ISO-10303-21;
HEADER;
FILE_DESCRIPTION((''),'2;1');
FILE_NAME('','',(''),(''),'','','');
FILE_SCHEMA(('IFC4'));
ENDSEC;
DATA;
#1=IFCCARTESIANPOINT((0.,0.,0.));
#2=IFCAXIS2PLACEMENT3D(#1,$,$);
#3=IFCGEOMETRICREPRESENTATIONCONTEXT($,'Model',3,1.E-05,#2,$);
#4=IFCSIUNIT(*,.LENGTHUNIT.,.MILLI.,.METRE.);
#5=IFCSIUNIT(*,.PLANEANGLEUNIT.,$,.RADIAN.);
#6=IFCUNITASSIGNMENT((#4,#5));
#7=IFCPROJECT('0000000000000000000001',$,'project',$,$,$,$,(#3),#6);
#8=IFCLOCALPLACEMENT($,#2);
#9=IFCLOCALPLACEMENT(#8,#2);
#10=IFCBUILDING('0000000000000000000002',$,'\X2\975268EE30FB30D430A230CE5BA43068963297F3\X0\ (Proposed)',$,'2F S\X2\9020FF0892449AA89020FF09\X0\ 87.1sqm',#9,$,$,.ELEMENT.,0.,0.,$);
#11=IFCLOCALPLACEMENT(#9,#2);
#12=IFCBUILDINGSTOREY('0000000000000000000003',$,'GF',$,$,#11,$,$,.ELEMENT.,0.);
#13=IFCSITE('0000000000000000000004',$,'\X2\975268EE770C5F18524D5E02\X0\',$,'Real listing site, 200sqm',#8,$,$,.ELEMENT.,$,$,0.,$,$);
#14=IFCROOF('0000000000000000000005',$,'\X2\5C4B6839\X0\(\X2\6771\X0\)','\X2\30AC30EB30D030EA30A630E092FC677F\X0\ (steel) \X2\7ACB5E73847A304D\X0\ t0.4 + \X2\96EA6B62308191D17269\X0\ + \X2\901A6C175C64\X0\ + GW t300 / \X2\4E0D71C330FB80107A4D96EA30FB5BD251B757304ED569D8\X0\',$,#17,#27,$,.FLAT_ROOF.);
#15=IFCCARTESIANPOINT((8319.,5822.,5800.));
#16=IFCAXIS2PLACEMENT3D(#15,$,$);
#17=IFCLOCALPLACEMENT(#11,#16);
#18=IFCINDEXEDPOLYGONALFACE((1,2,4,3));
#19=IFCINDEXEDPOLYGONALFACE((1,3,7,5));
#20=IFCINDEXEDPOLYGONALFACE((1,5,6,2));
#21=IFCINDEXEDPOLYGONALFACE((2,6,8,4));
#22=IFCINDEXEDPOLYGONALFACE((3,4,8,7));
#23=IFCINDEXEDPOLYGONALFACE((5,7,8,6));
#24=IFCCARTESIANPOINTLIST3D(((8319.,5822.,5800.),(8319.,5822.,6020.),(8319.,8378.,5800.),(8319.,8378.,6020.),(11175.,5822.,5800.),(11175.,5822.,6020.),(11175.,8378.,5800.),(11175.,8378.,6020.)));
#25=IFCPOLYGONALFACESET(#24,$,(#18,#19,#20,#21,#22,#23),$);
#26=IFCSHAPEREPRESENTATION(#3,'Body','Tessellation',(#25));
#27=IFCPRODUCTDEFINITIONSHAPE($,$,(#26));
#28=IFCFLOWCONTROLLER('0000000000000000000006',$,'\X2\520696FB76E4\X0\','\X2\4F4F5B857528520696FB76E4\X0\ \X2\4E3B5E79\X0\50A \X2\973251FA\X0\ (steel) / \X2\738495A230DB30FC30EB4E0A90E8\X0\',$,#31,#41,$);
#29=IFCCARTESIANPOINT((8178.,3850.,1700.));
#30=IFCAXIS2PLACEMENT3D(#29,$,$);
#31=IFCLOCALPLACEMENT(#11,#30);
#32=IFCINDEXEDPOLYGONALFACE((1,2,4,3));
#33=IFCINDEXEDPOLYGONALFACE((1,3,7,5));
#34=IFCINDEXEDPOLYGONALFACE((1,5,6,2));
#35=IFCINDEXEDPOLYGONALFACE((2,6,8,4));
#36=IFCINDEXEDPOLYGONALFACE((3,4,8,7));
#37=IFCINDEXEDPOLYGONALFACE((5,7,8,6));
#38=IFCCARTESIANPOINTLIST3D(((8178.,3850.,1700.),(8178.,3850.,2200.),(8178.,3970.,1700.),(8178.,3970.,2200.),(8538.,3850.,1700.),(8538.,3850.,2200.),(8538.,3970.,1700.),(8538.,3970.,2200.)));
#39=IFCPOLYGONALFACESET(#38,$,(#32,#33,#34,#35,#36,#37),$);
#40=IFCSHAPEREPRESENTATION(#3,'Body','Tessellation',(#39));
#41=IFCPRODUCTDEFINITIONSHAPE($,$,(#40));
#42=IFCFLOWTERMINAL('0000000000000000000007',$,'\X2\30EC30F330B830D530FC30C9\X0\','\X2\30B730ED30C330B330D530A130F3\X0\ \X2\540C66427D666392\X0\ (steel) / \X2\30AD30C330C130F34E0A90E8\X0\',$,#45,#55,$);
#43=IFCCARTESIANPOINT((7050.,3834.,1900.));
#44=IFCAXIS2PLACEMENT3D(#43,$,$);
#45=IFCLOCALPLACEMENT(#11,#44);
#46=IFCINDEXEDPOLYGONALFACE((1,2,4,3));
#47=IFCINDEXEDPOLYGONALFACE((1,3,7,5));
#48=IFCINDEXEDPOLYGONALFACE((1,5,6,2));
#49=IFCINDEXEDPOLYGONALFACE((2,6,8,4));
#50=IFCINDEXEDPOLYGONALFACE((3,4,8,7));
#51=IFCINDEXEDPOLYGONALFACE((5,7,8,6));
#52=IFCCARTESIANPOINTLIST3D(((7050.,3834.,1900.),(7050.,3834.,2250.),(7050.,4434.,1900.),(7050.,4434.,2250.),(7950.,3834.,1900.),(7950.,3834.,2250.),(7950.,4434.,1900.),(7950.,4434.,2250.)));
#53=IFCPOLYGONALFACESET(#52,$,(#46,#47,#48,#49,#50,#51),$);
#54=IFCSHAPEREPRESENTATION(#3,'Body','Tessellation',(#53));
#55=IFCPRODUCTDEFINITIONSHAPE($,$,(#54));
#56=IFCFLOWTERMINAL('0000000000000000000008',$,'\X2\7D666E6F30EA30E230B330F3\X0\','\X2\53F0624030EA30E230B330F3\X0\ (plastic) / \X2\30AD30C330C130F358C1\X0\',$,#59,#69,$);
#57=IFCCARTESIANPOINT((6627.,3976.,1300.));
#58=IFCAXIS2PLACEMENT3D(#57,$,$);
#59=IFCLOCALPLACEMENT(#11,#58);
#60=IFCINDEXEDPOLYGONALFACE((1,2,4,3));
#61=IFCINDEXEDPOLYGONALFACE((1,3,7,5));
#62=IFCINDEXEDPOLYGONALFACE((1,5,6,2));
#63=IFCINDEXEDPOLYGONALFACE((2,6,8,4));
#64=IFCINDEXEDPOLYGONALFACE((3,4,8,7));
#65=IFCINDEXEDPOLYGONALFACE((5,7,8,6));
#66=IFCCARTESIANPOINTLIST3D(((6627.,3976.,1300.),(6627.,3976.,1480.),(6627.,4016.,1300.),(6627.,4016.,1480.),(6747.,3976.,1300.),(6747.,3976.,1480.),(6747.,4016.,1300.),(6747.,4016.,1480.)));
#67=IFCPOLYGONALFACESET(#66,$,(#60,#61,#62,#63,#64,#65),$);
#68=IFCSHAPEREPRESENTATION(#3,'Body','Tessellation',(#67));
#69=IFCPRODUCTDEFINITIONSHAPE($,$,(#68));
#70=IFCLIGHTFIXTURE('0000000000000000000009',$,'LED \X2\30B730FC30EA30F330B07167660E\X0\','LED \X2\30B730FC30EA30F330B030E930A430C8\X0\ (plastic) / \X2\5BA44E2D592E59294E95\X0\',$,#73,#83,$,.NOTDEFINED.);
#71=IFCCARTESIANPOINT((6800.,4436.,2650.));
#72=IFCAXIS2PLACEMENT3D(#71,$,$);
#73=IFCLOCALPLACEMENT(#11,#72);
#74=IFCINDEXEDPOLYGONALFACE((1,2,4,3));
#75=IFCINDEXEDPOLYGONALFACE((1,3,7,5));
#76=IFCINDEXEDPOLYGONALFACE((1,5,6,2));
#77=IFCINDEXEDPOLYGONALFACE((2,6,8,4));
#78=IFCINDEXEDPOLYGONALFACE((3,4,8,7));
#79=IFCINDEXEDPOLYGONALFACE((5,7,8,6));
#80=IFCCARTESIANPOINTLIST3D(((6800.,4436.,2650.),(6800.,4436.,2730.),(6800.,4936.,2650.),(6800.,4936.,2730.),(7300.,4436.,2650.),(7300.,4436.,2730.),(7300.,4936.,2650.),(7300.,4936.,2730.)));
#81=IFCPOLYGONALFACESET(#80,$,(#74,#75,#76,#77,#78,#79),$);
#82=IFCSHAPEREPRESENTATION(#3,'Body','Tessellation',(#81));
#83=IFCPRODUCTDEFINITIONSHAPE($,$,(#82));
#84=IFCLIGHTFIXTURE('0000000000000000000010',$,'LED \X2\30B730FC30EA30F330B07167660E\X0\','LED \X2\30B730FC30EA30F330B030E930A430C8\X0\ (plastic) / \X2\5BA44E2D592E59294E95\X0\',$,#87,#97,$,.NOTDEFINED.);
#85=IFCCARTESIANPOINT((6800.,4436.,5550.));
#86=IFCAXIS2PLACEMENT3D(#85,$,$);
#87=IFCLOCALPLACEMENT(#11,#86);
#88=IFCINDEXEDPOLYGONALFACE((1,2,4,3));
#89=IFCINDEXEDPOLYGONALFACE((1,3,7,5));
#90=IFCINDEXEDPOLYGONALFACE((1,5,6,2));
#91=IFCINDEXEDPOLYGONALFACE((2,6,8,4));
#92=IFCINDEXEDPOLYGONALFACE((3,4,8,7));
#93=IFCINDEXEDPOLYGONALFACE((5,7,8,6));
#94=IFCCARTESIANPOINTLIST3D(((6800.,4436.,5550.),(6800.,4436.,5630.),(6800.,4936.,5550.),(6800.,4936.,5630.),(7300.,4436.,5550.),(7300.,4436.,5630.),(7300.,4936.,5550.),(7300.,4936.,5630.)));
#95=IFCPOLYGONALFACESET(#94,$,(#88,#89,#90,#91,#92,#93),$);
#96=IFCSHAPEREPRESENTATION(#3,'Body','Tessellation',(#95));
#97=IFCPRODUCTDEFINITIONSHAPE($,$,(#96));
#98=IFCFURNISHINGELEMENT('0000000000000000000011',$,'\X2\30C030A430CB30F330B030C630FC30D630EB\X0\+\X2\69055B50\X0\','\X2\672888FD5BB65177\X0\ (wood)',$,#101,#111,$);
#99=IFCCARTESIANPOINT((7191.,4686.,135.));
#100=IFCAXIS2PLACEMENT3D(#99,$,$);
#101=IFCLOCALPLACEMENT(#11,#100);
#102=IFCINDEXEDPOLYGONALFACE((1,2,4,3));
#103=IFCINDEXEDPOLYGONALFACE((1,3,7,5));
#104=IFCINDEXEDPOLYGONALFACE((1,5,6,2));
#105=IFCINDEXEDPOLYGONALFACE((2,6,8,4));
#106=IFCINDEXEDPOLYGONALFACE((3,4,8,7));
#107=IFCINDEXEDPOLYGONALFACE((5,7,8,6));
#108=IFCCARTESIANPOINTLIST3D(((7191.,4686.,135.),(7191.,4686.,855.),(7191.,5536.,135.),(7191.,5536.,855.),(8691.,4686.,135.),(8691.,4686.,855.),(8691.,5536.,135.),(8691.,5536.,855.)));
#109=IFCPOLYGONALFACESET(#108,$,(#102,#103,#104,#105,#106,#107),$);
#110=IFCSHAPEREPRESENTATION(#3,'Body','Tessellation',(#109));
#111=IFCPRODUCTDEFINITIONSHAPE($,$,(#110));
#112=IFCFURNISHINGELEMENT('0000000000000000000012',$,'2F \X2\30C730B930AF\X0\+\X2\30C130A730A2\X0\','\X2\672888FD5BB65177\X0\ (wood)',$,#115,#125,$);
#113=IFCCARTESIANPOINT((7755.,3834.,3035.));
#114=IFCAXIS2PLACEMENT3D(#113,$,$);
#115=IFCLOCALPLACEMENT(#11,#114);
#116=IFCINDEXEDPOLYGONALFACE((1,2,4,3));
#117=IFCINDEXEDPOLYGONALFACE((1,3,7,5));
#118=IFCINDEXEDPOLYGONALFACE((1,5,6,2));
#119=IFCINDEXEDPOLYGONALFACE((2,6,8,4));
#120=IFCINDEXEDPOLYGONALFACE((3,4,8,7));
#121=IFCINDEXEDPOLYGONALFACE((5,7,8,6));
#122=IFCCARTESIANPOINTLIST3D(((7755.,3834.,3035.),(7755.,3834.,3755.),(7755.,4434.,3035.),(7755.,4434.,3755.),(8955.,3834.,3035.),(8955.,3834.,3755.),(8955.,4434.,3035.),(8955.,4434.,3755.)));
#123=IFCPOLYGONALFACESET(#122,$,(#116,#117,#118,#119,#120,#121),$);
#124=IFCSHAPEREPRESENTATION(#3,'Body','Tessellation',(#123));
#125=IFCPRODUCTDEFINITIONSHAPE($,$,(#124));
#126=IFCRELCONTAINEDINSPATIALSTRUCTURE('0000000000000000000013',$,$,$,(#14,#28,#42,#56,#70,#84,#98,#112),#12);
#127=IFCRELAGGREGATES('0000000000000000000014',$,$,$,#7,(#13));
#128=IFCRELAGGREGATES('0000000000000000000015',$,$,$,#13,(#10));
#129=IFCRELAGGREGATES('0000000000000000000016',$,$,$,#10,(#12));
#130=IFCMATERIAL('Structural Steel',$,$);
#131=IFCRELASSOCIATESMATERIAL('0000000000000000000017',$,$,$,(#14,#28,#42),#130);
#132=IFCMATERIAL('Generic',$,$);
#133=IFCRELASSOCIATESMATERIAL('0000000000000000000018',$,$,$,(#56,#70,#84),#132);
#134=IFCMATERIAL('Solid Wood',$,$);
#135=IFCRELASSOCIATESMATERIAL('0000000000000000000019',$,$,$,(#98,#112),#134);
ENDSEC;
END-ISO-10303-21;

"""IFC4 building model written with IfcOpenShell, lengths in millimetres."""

from ifc_helpers import new_model, si_unit, frame, frame_2d, origin, place, context, project, spatial, rectangle, extrude, material, element, save


model = new_model("IFC4")

# Units and contexts
model_context = context("Model", 3, precision=1e-05, world=origin())
ifc_project = project(units=[si_unit("LENGTHUNIT", "METRE", prefix="MILLI"), si_unit("PLANEANGLEUNIT", "RADIAN")], contexts=[model_context])

# Site, building, storey
site_placement = place(None, origin())
site = spatial("IfcSite", under=ifc_project, at=site_placement, Name="青森県弘前市", ObjectType="Real listing site, 200sqm", CompositionType="ELEMENT", RefElevation=0.0)
building_placement = place(site_placement, origin())
building = spatial("IfcBuilding", under=site, at=building_placement, Name="青森・ピアノ室と防音 (Proposed)", ObjectType="2F S造（鉄骨造） 87.1sqm", CompositionType="ELEMENT", ElevationOfRefHeight=0.0, ElevationOfTerrain=0.0)
storey_placement = place(building_placement, origin())
storey = spatial("IfcBuildingStorey", under=building, at=storey_placement, Name="GF", CompositionType="ELEMENT", Elevation=0.0)

# Shared definitions
ifc_material_1 = material(Name="Solid Wood")

# Roof
ifc_material_2 = material(Name="Structural Steel")
for number, where, name in (
    (1, (8319.0, 5822.0, 5800.0), "屋根(東)"),
):
    element("IfcRoof", number, at=place(storey_placement, frame(where)), inside=storey, material=ifc_material_2, Name=name, Description="ガルバリウム鋼板 (steel) 立平葺き t0.4 + 雪止め金物 + 通気層 + GW t300 / 不燃・耐積雪・寒冷地仕様", PredefinedType="FLAT_ROOF", context=model_context, shape_type="SweptSolid", body=[
        extrude(rectangle(XDim=2856.0, YDim=2556.0, at=frame_2d((1428.0, 1278.0))), frame((8319.0, 5822.0, 5800.0)), (0.0, 0.0, 1.0), 220.0),
    ])

# Flow controller
flow_controller_placement = place(storey_placement, frame((8178.0, 3850.0, 1700.0)))
element("IfcFlowController", 2, at=flow_controller_placement, inside=storey, material=ifc_material_2, Name="分電盤", Description="住宅用分電盤 主幹50A 露出 (steel) / 玄関ホール上部", context=model_context, shape_type="SweptSolid", body=[
    extrude(rectangle(XDim=360.0, YDim=120.0, at=frame_2d((180.0, 60.0))), frame((8178.0, 3850.0, 1700.0)), (0.0, 0.0, 1.0), 500.0),
])

# Flow terminals
flow_terminal_1_placement = place(storey_placement, frame((7050.0, 3834.0, 1900.0)))
element("IfcFlowTerminal", 3, at=flow_terminal_1_placement, inside=storey, material=ifc_material_2, Name="レンジフード", Description="シロッコファン 同時給排 (steel) / キッチン上部", context=model_context, shape_type="SweptSolid", body=[
    extrude(rectangle(XDim=900.0, YDim=600.0, at=frame_2d((450.0, 300.0))), frame((7050.0, 3834.0, 1900.0)), (0.0, 0.0, 1.0), 350.0),
])
ifc_material_3 = material(Name="Generic")
flow_terminal_2_placement = place(storey_placement, frame((6627.0, 3976.0, 1300.0)))
element("IfcFlowTerminal", 4, at=flow_terminal_2_placement, inside=storey, material=ifc_material_3, Name="給湯リモコン", Description="台所リモコン (plastic) / キッチン壁", context=model_context, shape_type="SweptSolid", body=[
    extrude(rectangle(XDim=120.0, YDim=40.0, at=frame_2d((60.0, 20.0))), frame((6627.0, 3976.0, 1300.0)), (0.0, 0.0, 1.0), 180.0),
])

# Light fixtures
light_fixture_1_placement = place(storey_placement, frame((6800.0, 4436.0, 2650.0)))
element("IfcLightFixture", 5, at=light_fixture_1_placement, inside=storey, material=ifc_material_3, Name="LED シーリング照明", Description="LED シーリングライト (plastic) / 室中央天井", PredefinedType="NOTDEFINED", context=model_context, shape_type="SweptSolid", body=[
    extrude(rectangle(XDim=500.0, YDim=500.0, at=frame_2d((250.0, 250.0))), frame((6800.0, 4436.0, 2650.0)), (0.0, 0.0, 1.0), 80.0),
])
light_fixture_2_placement = place(storey_placement, frame((6800.0, 4436.0, 5550.0)))
element("IfcLightFixture", 6, at=light_fixture_2_placement, inside=storey, material=ifc_material_3, Name="LED シーリング照明", Description="LED シーリングライト (plastic) / 室中央天井", PredefinedType="NOTDEFINED", context=model_context, shape_type="SweptSolid", body=[
    extrude(rectangle(XDim=500.0, YDim=500.0, at=frame_2d((250.0, 250.0))), frame((6800.0, 4436.0, 5550.0)), (0.0, 0.0, 1.0), 80.0),
])

# Furnishing elements
furnishing_1_placement = place(storey_placement, frame((7191.0, 4686.0, 135.0)))
element("IfcFurnishingElement", 7, at=furnishing_1_placement, inside=storey, material=ifc_material_1, Name="ダイニングテーブル+椅子", Description="木製家具 (wood)", context=model_context, shape_type="SweptSolid", body=[
    extrude(rectangle(XDim=1500.0, YDim=850.0, at=frame_2d((750.0, 425.0))), frame((7191.0, 4686.0, 135.0)), (0.0, 0.0, 1.0), 720.0),
])
furnishing_2_placement = place(storey_placement, frame((7755.0, 3834.0, 3035.0)))
element("IfcFurnishingElement", 8, at=furnishing_2_placement, inside=storey, material=ifc_material_1, Name="2F デスク+チェア", Description="木製家具 (wood)", context=model_context, shape_type="SweptSolid", body=[
    extrude(rectangle(XDim=1200.0, YDim=600.0, at=frame_2d((600.0, 300.0))), frame((7755.0, 3834.0, 3035.0)), (0.0, 0.0, 1.0), 720.0),
])

save(model, "model.ifc")
